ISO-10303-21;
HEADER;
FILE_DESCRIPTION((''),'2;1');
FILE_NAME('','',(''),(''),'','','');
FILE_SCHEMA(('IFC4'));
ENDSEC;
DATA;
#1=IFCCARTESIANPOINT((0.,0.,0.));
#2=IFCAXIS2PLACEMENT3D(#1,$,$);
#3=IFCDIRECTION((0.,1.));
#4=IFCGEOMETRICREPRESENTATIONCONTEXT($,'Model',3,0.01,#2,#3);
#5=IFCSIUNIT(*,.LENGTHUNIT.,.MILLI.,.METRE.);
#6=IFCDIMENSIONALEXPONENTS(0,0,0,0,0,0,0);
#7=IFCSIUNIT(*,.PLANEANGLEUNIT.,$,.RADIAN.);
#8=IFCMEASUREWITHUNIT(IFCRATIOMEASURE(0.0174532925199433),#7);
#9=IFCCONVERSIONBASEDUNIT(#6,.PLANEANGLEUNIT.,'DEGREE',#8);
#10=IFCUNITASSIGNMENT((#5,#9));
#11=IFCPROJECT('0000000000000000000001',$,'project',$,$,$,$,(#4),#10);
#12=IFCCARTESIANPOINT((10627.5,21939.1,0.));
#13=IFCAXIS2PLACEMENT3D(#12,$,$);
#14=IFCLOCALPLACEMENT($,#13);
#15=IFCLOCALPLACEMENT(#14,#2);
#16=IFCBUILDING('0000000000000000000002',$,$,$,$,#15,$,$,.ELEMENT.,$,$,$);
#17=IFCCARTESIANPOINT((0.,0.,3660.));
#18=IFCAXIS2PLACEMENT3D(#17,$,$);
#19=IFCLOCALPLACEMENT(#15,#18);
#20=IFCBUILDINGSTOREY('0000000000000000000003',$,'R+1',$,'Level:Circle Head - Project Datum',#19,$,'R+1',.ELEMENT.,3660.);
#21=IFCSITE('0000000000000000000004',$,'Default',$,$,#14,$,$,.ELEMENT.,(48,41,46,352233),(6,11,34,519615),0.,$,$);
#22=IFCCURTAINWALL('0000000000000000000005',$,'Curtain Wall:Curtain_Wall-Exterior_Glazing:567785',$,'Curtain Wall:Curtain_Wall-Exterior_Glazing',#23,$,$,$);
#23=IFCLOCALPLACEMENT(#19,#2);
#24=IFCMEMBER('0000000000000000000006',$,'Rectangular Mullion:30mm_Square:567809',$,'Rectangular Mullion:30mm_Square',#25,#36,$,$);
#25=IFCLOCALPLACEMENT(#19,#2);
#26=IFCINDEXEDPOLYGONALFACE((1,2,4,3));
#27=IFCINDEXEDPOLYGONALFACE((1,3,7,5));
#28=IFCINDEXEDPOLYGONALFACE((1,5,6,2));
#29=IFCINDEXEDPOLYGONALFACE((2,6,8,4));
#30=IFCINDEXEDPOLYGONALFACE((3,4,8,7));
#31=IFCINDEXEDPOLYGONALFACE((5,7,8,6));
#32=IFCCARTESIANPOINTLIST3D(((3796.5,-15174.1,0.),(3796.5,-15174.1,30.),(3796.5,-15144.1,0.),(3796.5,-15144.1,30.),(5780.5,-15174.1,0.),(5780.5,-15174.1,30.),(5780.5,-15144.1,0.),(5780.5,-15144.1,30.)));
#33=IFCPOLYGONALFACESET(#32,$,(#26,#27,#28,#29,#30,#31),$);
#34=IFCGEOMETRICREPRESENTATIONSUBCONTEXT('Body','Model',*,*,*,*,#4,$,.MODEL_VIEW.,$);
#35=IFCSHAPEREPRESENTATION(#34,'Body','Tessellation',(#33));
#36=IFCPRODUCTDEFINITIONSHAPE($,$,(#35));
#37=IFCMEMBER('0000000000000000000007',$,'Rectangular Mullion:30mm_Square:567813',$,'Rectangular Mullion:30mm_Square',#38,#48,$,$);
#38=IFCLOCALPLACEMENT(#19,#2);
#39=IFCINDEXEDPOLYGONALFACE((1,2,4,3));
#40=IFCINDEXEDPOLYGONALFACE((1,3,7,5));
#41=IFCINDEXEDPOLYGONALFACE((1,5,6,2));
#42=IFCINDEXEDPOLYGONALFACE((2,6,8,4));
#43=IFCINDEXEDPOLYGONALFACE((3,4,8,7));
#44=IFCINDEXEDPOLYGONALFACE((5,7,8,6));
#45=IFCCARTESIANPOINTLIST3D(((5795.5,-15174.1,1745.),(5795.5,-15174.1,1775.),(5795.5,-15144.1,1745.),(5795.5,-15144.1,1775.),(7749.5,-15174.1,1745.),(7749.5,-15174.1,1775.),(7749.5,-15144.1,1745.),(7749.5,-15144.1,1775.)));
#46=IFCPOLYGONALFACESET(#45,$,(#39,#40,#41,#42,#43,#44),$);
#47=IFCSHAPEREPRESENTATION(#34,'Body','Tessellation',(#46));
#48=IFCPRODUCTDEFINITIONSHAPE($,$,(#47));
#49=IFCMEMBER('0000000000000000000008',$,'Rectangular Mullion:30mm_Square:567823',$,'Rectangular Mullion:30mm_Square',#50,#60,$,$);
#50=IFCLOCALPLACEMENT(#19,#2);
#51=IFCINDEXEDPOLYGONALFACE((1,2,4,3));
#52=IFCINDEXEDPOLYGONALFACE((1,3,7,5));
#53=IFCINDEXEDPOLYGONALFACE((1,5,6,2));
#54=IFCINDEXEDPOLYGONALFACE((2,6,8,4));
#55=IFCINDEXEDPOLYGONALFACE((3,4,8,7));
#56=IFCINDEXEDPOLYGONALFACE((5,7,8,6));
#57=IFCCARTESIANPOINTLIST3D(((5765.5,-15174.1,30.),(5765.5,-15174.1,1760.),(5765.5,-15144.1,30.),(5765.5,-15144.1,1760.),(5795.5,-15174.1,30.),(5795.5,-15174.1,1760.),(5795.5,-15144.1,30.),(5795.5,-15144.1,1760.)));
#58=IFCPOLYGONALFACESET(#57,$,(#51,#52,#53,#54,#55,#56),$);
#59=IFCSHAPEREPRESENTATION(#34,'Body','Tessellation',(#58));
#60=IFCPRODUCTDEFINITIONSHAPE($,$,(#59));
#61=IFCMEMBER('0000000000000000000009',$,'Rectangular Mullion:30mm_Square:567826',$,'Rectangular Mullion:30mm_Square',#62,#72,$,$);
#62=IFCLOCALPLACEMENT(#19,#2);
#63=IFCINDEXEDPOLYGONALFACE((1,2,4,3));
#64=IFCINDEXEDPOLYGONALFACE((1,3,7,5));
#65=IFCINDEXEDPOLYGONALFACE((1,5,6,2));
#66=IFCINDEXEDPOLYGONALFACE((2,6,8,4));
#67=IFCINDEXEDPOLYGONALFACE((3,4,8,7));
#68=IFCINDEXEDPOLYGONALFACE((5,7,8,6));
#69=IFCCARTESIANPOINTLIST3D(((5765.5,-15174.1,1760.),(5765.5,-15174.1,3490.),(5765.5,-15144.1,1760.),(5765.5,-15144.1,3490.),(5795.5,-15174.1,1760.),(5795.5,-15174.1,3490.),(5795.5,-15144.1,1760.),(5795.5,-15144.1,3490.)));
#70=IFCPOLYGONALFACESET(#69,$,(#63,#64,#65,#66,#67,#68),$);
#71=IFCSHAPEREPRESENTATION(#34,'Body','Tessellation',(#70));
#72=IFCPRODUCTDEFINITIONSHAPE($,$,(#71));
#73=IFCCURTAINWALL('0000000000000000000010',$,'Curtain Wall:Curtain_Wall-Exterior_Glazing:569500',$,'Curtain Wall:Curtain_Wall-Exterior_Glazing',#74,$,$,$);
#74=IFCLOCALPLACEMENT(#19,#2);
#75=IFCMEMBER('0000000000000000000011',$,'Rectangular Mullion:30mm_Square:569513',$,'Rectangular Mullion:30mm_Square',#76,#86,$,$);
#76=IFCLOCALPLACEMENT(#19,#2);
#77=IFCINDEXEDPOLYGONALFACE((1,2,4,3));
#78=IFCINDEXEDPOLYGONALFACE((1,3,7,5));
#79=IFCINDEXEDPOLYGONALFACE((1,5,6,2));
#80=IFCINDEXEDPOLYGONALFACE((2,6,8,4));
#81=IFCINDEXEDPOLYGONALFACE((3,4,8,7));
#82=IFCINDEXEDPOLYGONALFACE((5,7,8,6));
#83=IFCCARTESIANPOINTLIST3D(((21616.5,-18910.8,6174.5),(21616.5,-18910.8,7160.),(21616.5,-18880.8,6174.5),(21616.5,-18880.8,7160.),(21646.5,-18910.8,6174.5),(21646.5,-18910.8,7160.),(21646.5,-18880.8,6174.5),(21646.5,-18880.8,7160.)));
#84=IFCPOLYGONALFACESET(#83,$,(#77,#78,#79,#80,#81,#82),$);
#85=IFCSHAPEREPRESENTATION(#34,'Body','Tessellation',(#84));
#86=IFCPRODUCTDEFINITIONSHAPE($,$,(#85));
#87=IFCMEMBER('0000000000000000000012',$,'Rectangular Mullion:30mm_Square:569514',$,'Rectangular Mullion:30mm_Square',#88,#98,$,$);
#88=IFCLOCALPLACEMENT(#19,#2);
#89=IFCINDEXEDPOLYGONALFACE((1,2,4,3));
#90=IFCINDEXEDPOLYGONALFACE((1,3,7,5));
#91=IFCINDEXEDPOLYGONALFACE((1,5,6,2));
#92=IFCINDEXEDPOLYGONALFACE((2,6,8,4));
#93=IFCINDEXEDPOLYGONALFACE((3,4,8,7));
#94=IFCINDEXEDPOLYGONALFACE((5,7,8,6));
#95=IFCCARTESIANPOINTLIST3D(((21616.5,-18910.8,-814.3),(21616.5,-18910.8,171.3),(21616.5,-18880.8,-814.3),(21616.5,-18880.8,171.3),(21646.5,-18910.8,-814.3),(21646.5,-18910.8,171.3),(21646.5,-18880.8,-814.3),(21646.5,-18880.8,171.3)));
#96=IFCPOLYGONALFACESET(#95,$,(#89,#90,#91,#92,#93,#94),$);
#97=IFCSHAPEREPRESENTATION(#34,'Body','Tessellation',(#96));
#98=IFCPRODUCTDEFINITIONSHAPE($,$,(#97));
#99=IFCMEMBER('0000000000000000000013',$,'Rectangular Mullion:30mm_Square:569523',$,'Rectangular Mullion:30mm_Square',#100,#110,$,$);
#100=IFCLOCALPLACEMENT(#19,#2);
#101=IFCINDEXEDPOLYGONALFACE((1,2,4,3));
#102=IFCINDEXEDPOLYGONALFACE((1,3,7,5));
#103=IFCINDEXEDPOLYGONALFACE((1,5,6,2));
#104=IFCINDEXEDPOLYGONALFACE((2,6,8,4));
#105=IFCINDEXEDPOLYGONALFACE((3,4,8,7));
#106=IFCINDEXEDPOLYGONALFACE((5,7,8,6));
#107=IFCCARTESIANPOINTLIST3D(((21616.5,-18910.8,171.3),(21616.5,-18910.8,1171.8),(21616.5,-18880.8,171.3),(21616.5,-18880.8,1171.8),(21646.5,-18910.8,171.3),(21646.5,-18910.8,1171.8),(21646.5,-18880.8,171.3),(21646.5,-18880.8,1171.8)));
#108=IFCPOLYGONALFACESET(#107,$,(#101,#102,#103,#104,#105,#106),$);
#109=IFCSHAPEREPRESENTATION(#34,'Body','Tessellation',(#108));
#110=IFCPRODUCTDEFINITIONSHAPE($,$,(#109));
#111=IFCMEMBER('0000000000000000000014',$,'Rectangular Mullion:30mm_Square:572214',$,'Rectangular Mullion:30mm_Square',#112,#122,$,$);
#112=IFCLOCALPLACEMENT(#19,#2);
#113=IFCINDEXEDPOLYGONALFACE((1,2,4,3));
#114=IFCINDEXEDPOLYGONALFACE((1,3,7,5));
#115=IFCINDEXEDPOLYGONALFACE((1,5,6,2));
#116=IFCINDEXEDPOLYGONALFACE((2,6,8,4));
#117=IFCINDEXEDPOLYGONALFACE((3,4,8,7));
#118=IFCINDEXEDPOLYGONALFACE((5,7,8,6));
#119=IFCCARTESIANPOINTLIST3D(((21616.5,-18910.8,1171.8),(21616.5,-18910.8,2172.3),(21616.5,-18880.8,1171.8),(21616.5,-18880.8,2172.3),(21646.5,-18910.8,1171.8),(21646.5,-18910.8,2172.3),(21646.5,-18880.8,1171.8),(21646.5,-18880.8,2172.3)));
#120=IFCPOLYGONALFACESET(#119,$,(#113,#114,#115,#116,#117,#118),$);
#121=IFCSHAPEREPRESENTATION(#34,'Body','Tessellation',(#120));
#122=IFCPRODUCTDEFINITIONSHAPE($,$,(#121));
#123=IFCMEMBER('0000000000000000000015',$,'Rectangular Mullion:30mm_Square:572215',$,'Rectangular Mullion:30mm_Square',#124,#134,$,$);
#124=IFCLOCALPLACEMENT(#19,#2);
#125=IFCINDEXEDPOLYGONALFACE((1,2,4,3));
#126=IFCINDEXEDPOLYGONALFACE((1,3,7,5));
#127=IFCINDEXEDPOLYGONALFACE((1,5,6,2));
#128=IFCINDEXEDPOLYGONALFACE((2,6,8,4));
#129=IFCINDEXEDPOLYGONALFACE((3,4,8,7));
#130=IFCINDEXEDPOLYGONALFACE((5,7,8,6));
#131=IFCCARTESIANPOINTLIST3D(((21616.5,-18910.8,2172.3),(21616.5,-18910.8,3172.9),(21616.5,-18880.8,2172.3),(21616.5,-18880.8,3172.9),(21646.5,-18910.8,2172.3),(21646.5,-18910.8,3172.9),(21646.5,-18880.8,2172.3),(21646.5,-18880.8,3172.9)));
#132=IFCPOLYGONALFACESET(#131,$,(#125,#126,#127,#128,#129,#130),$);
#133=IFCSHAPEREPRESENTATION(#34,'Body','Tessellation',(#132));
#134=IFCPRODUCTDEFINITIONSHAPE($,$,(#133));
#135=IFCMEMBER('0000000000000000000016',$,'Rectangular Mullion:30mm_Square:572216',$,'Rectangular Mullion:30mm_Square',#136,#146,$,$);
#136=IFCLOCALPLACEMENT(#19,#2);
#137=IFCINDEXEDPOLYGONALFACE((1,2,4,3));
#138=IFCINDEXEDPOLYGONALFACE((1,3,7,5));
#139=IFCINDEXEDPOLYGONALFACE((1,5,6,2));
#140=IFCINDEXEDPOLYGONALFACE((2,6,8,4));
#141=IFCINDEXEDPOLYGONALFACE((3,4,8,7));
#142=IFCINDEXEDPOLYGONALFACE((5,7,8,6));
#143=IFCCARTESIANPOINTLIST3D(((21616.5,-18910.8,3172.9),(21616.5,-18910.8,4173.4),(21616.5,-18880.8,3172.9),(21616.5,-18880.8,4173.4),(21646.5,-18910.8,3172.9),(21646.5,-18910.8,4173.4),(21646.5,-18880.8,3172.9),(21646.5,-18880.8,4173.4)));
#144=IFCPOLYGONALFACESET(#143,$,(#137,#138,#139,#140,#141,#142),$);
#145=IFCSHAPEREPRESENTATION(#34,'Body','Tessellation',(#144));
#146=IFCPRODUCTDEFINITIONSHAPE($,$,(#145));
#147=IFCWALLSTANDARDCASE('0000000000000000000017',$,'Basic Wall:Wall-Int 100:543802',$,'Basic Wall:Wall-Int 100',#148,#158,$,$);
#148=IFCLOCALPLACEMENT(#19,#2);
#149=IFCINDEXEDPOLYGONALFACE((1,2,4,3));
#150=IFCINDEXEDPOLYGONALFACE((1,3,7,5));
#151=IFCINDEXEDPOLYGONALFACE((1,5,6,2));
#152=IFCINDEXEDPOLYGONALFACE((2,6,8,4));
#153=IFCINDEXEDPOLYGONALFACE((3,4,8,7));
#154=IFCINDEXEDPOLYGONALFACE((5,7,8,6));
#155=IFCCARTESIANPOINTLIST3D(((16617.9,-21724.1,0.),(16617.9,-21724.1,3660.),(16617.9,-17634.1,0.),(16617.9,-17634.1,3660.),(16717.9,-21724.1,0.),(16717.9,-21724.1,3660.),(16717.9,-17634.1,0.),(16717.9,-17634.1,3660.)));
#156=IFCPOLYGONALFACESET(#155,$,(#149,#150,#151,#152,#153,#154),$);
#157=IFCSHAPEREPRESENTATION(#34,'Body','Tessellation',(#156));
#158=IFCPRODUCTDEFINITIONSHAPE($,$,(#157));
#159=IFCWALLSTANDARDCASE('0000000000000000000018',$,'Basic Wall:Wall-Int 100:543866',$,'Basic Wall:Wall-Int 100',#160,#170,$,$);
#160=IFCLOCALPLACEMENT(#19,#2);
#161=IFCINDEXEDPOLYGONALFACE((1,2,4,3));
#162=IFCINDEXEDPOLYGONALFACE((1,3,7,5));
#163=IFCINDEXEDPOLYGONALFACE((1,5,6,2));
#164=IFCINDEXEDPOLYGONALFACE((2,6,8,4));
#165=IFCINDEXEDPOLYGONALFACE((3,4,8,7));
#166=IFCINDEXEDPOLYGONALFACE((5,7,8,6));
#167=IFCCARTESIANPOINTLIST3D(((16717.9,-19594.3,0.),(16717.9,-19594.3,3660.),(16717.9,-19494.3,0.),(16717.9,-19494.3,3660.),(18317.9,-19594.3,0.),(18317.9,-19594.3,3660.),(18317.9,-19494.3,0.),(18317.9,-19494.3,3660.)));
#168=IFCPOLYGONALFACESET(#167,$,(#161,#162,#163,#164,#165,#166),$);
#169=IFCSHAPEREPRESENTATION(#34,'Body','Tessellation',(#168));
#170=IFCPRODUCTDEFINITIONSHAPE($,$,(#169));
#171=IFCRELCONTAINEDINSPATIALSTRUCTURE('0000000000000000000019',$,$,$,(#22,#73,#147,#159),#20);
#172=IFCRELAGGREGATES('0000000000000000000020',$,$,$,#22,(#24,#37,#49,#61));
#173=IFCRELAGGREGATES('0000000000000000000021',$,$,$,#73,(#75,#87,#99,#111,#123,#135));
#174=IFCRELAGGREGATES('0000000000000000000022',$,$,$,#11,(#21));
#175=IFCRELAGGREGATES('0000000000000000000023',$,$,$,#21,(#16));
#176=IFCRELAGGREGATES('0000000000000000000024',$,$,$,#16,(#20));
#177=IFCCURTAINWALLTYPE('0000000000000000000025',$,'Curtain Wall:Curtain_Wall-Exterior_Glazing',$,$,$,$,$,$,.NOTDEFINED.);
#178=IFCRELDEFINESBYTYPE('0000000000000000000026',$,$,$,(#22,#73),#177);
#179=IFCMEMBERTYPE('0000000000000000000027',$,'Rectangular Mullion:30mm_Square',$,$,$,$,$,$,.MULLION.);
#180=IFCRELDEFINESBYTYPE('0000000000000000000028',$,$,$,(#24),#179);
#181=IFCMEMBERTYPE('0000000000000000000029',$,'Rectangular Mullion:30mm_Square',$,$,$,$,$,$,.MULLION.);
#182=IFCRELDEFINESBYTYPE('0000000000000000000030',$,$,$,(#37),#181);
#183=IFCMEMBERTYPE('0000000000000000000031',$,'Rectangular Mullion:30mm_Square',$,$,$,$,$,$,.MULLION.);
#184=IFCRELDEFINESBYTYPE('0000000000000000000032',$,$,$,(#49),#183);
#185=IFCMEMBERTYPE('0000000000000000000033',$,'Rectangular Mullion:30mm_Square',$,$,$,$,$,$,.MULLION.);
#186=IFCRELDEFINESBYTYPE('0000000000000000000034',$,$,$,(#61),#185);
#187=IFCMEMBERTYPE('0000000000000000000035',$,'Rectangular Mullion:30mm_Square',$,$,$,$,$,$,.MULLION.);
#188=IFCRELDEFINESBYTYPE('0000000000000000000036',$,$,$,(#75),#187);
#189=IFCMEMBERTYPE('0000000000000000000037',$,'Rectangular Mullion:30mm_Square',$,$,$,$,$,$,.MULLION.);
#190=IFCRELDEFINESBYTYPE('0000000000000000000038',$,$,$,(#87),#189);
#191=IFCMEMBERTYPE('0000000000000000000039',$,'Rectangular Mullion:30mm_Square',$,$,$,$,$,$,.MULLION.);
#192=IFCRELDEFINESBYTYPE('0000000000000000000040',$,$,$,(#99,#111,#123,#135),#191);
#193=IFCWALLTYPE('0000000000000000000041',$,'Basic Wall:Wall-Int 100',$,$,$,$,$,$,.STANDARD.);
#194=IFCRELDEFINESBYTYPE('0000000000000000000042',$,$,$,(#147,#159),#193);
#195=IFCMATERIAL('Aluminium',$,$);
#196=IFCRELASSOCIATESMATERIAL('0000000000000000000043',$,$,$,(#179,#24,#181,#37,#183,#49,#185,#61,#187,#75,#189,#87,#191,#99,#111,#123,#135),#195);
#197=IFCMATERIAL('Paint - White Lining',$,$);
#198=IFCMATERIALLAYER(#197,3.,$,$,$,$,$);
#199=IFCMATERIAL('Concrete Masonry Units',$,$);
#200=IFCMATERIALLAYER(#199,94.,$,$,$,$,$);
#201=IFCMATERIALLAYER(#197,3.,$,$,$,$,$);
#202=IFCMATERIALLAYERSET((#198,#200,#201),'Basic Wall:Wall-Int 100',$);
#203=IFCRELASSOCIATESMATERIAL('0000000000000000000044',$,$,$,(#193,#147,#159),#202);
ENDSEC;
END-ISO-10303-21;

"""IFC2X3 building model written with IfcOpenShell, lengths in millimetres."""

from ifc_helpers import new_model, entity, si_unit, converted_unit, direction, frame, frame_2d, origin, origin_2d_with_axis, place, context, subcontext, project, spatial, rectangle, extrude, source, transform, mapped, material, layer, layer_set, layer_usage, type_object, type_shapes, element, aggregate, save


model = new_model("IFC2X3")

# Units and contexts
model_context = context("Model", 3, precision=0.01, world=origin(), true_north=direction((0.0, 1.0)))
body_context = subcontext(model_context, "Body", "Model", "MODEL_VIEW")
ifc_project = project(units=[si_unit("LENGTHUNIT", "METRE", prefix="MILLI"), converted_unit("PLANEANGLEUNIT", "DEGREE", entity("IfcRatioMeasure", 0.0174532925199433), si_unit("PLANEANGLEUNIT", "RADIAN"), dimensions=[0, 0, 0, 0, 0, 0, 0])], contexts=[model_context])

# Site, building, storey
site_placement = place(None, frame((10627.5, 21939.1, 0.0)))
site = spatial("IfcSite", under=ifc_project, at=site_placement, Name="Default", CompositionType="ELEMENT", RefLatitude=(48, 41, 46, 352233), RefLongitude=(6, 11, 34, 519615), RefElevation=0.0)
building_placement = place(site_placement, origin())
building = spatial("IfcBuilding", under=site, at=building_placement, CompositionType="ELEMENT")
storey_placement = place(building_placement, frame((0.0, 0.0, 3660.0)))
storey = spatial("IfcBuildingStorey", under=building, at=storey_placement, Name="R+1", ObjectType="Level:Circle Head - Project Datum", LongName="R+1", CompositionType="ELEMENT", Elevation=3660.0)

# Curtain walls, members
curtain_wall_type = type_object("IfcCurtainWallType", Name="Curtain Wall:Curtain_Wall-Exterior_Glazing", PredefinedType="NOTDEFINED")
curtain_wall_1_placement = place(storey_placement, frame((0.0, 0.0, -3660.0)))
curtain_wall_1 = element("IfcCurtainWall", 1, at=curtain_wall_1_placement, inside=storey, type_object=curtain_wall_type, Name="Curtain Wall:Curtain_Wall-Exterior_Glazing:567785", ObjectType="Curtain Wall:Curtain_Wall-Exterior_Glazing")
ifc_material_1 = material(Name="Aluminium")
member_type_1 = type_object("IfcMemberType", Name="Rectangular Mullion:30mm_Square", PredefinedType="MULLION", material=ifc_material_1)
shared_shape_1 = source(origin(), body_context, "Body", "SweptSolid", [
    extrude(rectangle(XDim=30.0, YDim=30.0, at=origin_2d_with_axis()), frame((-15.0, 0.0, -1984.0), z_axis=(0.0, 0.0, 1.0), x_axis=(0.0, -1.0, 0.0)), (0.0, 0.0, 1.0), 1984.0),
])
type_shapes(member_type_1, [shared_shape_1])
member_1_placement = place(storey_placement, frame((5780.5, -15159.1, 0.0), z_axis=(1.0, 0.0, 0.0), x_axis=(0.0, 0.0, -1.0)))
member_1 = element("IfcMember", 2, at=member_1_placement, type_object=member_type_1, material=ifc_material_1, Name="Rectangular Mullion:30mm_Square:567809", ObjectType="Rectangular Mullion:30mm_Square", context=body_context, shape_type="MappedRepresentation", body=[
    mapped(shared_shape_1, transform((0.0, 0.0, 0.0), scale=1.0)),
])
member_type_2 = type_object("IfcMemberType", Name="Rectangular Mullion:30mm_Square", PredefinedType="MULLION", material=ifc_material_1)
shared_shape_2 = source(origin(), body_context, "Body", "SweptSolid", [
    extrude(rectangle(XDim=30.0, YDim=30.0, at=origin_2d_with_axis()), frame((0.0, 0.0, -1954.0), z_axis=(0.0, 0.0, 1.0), x_axis=(0.0, -1.0, 0.0)), (0.0, 0.0, 1.0), 1954.0),
])
type_shapes(member_type_2, [shared_shape_2])
member_2_placement = place(storey_placement, frame((5795.5, -15159.1, 1760.0), z_axis=(-1.0, 0.0, 0.0), x_axis=(0.0, 0.0, 1.0)))
member_2 = element("IfcMember", 3, at=member_2_placement, type_object=member_type_2, material=ifc_material_1, Name="Rectangular Mullion:30mm_Square:567813", ObjectType="Rectangular Mullion:30mm_Square", context=body_context, shape_type="MappedRepresentation", body=[
    mapped(shared_shape_2, transform((0.0, 0.0, 0.0), scale=1.0)),
])
member_type_3 = type_object("IfcMemberType", Name="Rectangular Mullion:30mm_Square", PredefinedType="MULLION", material=ifc_material_1)
shared_shape_3 = source(origin(), body_context, "Body", "SweptSolid", [
    extrude(rectangle(XDim=30.0, YDim=30.0, at=origin_2d_with_axis()), frame((0.0, 0.0, -1730.0), z_axis=(0.0, 0.0, 1.0), x_axis=(0.0, -1.0, 0.0)), (0.0, 0.0, 1.0), 1730.0),
])
type_shapes(member_type_3, [shared_shape_3])
member_3_placement = place(storey_placement, frame((5780.5, -15159.1, 30.0), z_axis=(0.0, 0.0, -1.0), x_axis=(-1.0, 0.0, 0.0)))
member_3 = element("IfcMember", 4, at=member_3_placement, type_object=member_type_3, material=ifc_material_1, Name="Rectangular Mullion:30mm_Square:567823", ObjectType="Rectangular Mullion:30mm_Square", context=body_context, shape_type="MappedRepresentation", body=[
    mapped(shared_shape_3, transform((0.0, 0.0, 0.0), scale=1.0)),
])
member_type_4 = type_object("IfcMemberType", Name="Rectangular Mullion:30mm_Square", PredefinedType="MULLION", material=ifc_material_1)
shared_shape_4 = source(origin(), body_context, "Body", "SweptSolid", [
    extrude(rectangle(XDim=30.0, YDim=30.0, at=origin_2d_with_axis()), frame((0.0, 0.0, -1730.0), z_axis=(0.0, 0.0, 1.0), x_axis=(0.0, -1.0, 0.0)), (0.0, 0.0, 1.0), 1730.0),
])
type_shapes(member_type_4, [shared_shape_4])
member_4_placement = place(storey_placement, frame((5780.5, -15159.1, 1760.0), z_axis=(0.0, 0.0, -1.0), x_axis=(-1.0, 0.0, 0.0)))
member_4 = element("IfcMember", 5, at=member_4_placement, type_object=member_type_4, material=ifc_material_1, Name="Rectangular Mullion:30mm_Square:567826", ObjectType="Rectangular Mullion:30mm_Square", context=body_context, shape_type="MappedRepresentation", body=[
    mapped(shared_shape_4, transform((0.0, 0.0, 0.0), scale=1.0)),
])
aggregate(curtain_wall_1, [member_1, member_2, member_3, member_4])
curtain_wall_2_placement = place(storey_placement, frame((0.0, 0.0, -3660.0)))
curtain_wall_2 = element("IfcCurtainWall", 6, at=curtain_wall_2_placement, inside=storey, type_object=curtain_wall_type, Name="Curtain Wall:Curtain_Wall-Exterior_Glazing:569500", ObjectType="Curtain Wall:Curtain_Wall-Exterior_Glazing")
member_type_5 = type_object("IfcMemberType", Name="Rectangular Mullion:30mm_Square", PredefinedType="MULLION", material=ifc_material_1)
shared_shape_5 = source(origin(), body_context, "Body", "SweptSolid", [
    extrude(rectangle(XDim=30.0, YDim=30.0, at=origin_2d_with_axis()), frame((-15.0, 0.0, -985.5), z_axis=(0.0, 0.0, 1.0), x_axis=(0.0, -1.0, 0.0)), (0.0, 0.0, 1.0), 985.5),
])
type_shapes(member_type_5, [shared_shape_5])
member_5_placement = place(storey_placement, frame((21616.5, -18895.8, 7160.0), z_axis=(0.0, 0.0, 1.0), x_axis=(-1.0, 0.0, 0.0)))
member_5 = element("IfcMember", 7, at=member_5_placement, type_object=member_type_5, material=ifc_material_1, Name="Rectangular Mullion:30mm_Square:569513", ObjectType="Rectangular Mullion:30mm_Square", context=body_context, shape_type="MappedRepresentation", body=[
    mapped(shared_shape_5, transform((0.0, 0.0, 0.0), scale=1.0)),
])
member_type_6 = type_object("IfcMemberType", Name="Rectangular Mullion:30mm_Square", PredefinedType="MULLION", material=ifc_material_1)
shared_shape_6 = source(origin(), body_context, "Body", "SweptSolid", [
    extrude(rectangle(XDim=30.0, YDim=30.0, at=origin_2d_with_axis()), frame((-15.0, 0.0, -985.5), z_axis=(0.0, 0.0, 1.0), x_axis=(0.0, -1.0, 0.0)), (0.0, 0.0, 1.0), 985.5),
])
type_shapes(member_type_6, [shared_shape_6])
member_6_placement = place(storey_placement, frame((21616.5, -18895.8, 171.3), z_axis=(0.0, 0.0, 1.0), x_axis=(-1.0, 0.0, 0.0)))
member_6 = element("IfcMember", 8, at=member_6_placement, type_object=member_type_6, material=ifc_material_1, Name="Rectangular Mullion:30mm_Square:569514", ObjectType="Rectangular Mullion:30mm_Square", context=body_context, shape_type="MappedRepresentation", body=[
    mapped(shared_shape_6, transform((0.0, 0.0, 0.0), scale=1.0)),
])
member_type_7 = type_object("IfcMemberType", Name="Rectangular Mullion:30mm_Square", PredefinedType="MULLION", material=ifc_material_1)
shared_shape_7 = source(origin(), body_context, "Body", "SweptSolid", [
    extrude(rectangle(XDim=30.0, YDim=30.0, at=origin_2d_with_axis()), frame((-15.0, 0.0, -1000.5), z_axis=(0.0, 0.0, 1.0), x_axis=(0.0, -1.0, 0.0)), (0.0, 0.0, 1.0), 1000.5),
])
type_shapes(member_type_7, [shared_shape_7])
member_7_placement = place(storey_placement, frame((21616.5, -18895.8, 1171.8), z_axis=(0.0, 0.0, 1.0), x_axis=(-1.0, 0.0, 0.0)))
member_7 = element("IfcMember", 9, at=member_7_placement, type_object=member_type_7, material=ifc_material_1, Name="Rectangular Mullion:30mm_Square:569523", ObjectType="Rectangular Mullion:30mm_Square", context=body_context, shape_type="MappedRepresentation", body=[
    mapped(shared_shape_7, transform((0.0, 0.0, 0.0), scale=1.0)),
])
member_8_placement = place(storey_placement, frame((21616.5, -18895.8, 2172.3), z_axis=(0.0, 0.0, 1.0), x_axis=(-1.0, 0.0, 0.0)))
member_8 = element("IfcMember", 10, at=member_8_placement, type_object=member_type_7, material=ifc_material_1, Name="Rectangular Mullion:30mm_Square:572214", ObjectType="Rectangular Mullion:30mm_Square", context=body_context, shape_type="MappedRepresentation", body=[
    mapped(shared_shape_7, transform((0.0, 0.0, 0.0), scale=1.0)),
])
member_9_placement = place(storey_placement, frame((21616.5, -18895.8, 3172.9), z_axis=(0.0, 0.0, 1.0), x_axis=(-1.0, 0.0, 0.0)))
member_9 = element("IfcMember", 11, at=member_9_placement, type_object=member_type_7, material=ifc_material_1, Name="Rectangular Mullion:30mm_Square:572215", ObjectType="Rectangular Mullion:30mm_Square", context=body_context, shape_type="MappedRepresentation", body=[
    mapped(shared_shape_7, transform((0.0, 0.0, 0.0), scale=1.0)),
])
member_10_placement = place(storey_placement, frame((21616.5, -18895.8, 4173.4), z_axis=(0.0, 0.0, 1.0), x_axis=(-1.0, 0.0, 0.0)))
member_10 = element("IfcMember", 12, at=member_10_placement, type_object=member_type_7, material=ifc_material_1, Name="Rectangular Mullion:30mm_Square:572216", ObjectType="Rectangular Mullion:30mm_Square", context=body_context, shape_type="MappedRepresentation", body=[
    mapped(shared_shape_7, transform((0.0, 0.0, 0.0), scale=1.0)),
])
aggregate(curtain_wall_2, [member_5, member_6, member_7, member_8, member_9, member_10])

# Walls
ifc_material_2 = material(Name="Paint - White Lining")
ifc_layer_1 = layer(ifc_material_2, 3.0)
ifc_material_3 = material(Name="Concrete Masonry Units")
ifc_layer_2 = layer(ifc_material_3, 94.0)
ifc_layer_3 = layer(ifc_material_2, 3.0)
ifc_layer_set_1 = layer_set([ifc_layer_1, ifc_layer_2, ifc_layer_3], Name="Basic Wall:Wall-Int 100")
ifc_layer_usage_1 = layer_usage(ifc_layer_set_1, "AXIS2", "POSITIVE", -50.0)
wall_type_1 = type_object("IfcWallType", Name="Basic Wall:Wall-Int 100", PredefinedType="STANDARD", material=ifc_layer_set_1)
wall_1_placement = place(storey_placement, frame((16667.9, -17634.1, 0.0), z_axis=(0.0, 0.0, 1.0), x_axis=(0.0, -1.0, 0.0)))
element("IfcWallStandardCase", 13, at=wall_1_placement, inside=storey, type_object=wall_type_1, material=ifc_layer_usage_1, Name="Basic Wall:Wall-Int 100:543802", ObjectType="Basic Wall:Wall-Int 100", context=body_context, shape_type="SweptSolid", body=[
    extrude(rectangle(XDim=4090.0, YDim=100.0, at=frame_2d((2045.0, 0.0), x_axis=(-1.0, 0.0))), origin(), (0.0, 0.0, 1.0), 3660.0),
])
ifc_layer_usage_2 = layer_usage(ifc_layer_set_1, "AXIS2", "POSITIVE", -50.0)
wall_2_placement = place(storey_placement, frame((18317.9, -19544.3, 0.0), z_axis=(0.0, 0.0, 1.0), x_axis=(-1.0, 0.0, 0.0)))
element("IfcWallStandardCase", 14, at=wall_2_placement, inside=storey, type_object=wall_type_1, material=ifc_layer_usage_2, Name="Basic Wall:Wall-Int 100:543866", ObjectType="Basic Wall:Wall-Int 100", context=body_context, shape_type="SweptSolid", body=[
    extrude(rectangle(XDim=1600.0, YDim=100.0, at=frame_2d((800.0, 0.0), x_axis=(-1.0, 0.0))), origin(), (0.0, 0.0, 1.0), 3660.0),
])

save(model, "model.ifc")
